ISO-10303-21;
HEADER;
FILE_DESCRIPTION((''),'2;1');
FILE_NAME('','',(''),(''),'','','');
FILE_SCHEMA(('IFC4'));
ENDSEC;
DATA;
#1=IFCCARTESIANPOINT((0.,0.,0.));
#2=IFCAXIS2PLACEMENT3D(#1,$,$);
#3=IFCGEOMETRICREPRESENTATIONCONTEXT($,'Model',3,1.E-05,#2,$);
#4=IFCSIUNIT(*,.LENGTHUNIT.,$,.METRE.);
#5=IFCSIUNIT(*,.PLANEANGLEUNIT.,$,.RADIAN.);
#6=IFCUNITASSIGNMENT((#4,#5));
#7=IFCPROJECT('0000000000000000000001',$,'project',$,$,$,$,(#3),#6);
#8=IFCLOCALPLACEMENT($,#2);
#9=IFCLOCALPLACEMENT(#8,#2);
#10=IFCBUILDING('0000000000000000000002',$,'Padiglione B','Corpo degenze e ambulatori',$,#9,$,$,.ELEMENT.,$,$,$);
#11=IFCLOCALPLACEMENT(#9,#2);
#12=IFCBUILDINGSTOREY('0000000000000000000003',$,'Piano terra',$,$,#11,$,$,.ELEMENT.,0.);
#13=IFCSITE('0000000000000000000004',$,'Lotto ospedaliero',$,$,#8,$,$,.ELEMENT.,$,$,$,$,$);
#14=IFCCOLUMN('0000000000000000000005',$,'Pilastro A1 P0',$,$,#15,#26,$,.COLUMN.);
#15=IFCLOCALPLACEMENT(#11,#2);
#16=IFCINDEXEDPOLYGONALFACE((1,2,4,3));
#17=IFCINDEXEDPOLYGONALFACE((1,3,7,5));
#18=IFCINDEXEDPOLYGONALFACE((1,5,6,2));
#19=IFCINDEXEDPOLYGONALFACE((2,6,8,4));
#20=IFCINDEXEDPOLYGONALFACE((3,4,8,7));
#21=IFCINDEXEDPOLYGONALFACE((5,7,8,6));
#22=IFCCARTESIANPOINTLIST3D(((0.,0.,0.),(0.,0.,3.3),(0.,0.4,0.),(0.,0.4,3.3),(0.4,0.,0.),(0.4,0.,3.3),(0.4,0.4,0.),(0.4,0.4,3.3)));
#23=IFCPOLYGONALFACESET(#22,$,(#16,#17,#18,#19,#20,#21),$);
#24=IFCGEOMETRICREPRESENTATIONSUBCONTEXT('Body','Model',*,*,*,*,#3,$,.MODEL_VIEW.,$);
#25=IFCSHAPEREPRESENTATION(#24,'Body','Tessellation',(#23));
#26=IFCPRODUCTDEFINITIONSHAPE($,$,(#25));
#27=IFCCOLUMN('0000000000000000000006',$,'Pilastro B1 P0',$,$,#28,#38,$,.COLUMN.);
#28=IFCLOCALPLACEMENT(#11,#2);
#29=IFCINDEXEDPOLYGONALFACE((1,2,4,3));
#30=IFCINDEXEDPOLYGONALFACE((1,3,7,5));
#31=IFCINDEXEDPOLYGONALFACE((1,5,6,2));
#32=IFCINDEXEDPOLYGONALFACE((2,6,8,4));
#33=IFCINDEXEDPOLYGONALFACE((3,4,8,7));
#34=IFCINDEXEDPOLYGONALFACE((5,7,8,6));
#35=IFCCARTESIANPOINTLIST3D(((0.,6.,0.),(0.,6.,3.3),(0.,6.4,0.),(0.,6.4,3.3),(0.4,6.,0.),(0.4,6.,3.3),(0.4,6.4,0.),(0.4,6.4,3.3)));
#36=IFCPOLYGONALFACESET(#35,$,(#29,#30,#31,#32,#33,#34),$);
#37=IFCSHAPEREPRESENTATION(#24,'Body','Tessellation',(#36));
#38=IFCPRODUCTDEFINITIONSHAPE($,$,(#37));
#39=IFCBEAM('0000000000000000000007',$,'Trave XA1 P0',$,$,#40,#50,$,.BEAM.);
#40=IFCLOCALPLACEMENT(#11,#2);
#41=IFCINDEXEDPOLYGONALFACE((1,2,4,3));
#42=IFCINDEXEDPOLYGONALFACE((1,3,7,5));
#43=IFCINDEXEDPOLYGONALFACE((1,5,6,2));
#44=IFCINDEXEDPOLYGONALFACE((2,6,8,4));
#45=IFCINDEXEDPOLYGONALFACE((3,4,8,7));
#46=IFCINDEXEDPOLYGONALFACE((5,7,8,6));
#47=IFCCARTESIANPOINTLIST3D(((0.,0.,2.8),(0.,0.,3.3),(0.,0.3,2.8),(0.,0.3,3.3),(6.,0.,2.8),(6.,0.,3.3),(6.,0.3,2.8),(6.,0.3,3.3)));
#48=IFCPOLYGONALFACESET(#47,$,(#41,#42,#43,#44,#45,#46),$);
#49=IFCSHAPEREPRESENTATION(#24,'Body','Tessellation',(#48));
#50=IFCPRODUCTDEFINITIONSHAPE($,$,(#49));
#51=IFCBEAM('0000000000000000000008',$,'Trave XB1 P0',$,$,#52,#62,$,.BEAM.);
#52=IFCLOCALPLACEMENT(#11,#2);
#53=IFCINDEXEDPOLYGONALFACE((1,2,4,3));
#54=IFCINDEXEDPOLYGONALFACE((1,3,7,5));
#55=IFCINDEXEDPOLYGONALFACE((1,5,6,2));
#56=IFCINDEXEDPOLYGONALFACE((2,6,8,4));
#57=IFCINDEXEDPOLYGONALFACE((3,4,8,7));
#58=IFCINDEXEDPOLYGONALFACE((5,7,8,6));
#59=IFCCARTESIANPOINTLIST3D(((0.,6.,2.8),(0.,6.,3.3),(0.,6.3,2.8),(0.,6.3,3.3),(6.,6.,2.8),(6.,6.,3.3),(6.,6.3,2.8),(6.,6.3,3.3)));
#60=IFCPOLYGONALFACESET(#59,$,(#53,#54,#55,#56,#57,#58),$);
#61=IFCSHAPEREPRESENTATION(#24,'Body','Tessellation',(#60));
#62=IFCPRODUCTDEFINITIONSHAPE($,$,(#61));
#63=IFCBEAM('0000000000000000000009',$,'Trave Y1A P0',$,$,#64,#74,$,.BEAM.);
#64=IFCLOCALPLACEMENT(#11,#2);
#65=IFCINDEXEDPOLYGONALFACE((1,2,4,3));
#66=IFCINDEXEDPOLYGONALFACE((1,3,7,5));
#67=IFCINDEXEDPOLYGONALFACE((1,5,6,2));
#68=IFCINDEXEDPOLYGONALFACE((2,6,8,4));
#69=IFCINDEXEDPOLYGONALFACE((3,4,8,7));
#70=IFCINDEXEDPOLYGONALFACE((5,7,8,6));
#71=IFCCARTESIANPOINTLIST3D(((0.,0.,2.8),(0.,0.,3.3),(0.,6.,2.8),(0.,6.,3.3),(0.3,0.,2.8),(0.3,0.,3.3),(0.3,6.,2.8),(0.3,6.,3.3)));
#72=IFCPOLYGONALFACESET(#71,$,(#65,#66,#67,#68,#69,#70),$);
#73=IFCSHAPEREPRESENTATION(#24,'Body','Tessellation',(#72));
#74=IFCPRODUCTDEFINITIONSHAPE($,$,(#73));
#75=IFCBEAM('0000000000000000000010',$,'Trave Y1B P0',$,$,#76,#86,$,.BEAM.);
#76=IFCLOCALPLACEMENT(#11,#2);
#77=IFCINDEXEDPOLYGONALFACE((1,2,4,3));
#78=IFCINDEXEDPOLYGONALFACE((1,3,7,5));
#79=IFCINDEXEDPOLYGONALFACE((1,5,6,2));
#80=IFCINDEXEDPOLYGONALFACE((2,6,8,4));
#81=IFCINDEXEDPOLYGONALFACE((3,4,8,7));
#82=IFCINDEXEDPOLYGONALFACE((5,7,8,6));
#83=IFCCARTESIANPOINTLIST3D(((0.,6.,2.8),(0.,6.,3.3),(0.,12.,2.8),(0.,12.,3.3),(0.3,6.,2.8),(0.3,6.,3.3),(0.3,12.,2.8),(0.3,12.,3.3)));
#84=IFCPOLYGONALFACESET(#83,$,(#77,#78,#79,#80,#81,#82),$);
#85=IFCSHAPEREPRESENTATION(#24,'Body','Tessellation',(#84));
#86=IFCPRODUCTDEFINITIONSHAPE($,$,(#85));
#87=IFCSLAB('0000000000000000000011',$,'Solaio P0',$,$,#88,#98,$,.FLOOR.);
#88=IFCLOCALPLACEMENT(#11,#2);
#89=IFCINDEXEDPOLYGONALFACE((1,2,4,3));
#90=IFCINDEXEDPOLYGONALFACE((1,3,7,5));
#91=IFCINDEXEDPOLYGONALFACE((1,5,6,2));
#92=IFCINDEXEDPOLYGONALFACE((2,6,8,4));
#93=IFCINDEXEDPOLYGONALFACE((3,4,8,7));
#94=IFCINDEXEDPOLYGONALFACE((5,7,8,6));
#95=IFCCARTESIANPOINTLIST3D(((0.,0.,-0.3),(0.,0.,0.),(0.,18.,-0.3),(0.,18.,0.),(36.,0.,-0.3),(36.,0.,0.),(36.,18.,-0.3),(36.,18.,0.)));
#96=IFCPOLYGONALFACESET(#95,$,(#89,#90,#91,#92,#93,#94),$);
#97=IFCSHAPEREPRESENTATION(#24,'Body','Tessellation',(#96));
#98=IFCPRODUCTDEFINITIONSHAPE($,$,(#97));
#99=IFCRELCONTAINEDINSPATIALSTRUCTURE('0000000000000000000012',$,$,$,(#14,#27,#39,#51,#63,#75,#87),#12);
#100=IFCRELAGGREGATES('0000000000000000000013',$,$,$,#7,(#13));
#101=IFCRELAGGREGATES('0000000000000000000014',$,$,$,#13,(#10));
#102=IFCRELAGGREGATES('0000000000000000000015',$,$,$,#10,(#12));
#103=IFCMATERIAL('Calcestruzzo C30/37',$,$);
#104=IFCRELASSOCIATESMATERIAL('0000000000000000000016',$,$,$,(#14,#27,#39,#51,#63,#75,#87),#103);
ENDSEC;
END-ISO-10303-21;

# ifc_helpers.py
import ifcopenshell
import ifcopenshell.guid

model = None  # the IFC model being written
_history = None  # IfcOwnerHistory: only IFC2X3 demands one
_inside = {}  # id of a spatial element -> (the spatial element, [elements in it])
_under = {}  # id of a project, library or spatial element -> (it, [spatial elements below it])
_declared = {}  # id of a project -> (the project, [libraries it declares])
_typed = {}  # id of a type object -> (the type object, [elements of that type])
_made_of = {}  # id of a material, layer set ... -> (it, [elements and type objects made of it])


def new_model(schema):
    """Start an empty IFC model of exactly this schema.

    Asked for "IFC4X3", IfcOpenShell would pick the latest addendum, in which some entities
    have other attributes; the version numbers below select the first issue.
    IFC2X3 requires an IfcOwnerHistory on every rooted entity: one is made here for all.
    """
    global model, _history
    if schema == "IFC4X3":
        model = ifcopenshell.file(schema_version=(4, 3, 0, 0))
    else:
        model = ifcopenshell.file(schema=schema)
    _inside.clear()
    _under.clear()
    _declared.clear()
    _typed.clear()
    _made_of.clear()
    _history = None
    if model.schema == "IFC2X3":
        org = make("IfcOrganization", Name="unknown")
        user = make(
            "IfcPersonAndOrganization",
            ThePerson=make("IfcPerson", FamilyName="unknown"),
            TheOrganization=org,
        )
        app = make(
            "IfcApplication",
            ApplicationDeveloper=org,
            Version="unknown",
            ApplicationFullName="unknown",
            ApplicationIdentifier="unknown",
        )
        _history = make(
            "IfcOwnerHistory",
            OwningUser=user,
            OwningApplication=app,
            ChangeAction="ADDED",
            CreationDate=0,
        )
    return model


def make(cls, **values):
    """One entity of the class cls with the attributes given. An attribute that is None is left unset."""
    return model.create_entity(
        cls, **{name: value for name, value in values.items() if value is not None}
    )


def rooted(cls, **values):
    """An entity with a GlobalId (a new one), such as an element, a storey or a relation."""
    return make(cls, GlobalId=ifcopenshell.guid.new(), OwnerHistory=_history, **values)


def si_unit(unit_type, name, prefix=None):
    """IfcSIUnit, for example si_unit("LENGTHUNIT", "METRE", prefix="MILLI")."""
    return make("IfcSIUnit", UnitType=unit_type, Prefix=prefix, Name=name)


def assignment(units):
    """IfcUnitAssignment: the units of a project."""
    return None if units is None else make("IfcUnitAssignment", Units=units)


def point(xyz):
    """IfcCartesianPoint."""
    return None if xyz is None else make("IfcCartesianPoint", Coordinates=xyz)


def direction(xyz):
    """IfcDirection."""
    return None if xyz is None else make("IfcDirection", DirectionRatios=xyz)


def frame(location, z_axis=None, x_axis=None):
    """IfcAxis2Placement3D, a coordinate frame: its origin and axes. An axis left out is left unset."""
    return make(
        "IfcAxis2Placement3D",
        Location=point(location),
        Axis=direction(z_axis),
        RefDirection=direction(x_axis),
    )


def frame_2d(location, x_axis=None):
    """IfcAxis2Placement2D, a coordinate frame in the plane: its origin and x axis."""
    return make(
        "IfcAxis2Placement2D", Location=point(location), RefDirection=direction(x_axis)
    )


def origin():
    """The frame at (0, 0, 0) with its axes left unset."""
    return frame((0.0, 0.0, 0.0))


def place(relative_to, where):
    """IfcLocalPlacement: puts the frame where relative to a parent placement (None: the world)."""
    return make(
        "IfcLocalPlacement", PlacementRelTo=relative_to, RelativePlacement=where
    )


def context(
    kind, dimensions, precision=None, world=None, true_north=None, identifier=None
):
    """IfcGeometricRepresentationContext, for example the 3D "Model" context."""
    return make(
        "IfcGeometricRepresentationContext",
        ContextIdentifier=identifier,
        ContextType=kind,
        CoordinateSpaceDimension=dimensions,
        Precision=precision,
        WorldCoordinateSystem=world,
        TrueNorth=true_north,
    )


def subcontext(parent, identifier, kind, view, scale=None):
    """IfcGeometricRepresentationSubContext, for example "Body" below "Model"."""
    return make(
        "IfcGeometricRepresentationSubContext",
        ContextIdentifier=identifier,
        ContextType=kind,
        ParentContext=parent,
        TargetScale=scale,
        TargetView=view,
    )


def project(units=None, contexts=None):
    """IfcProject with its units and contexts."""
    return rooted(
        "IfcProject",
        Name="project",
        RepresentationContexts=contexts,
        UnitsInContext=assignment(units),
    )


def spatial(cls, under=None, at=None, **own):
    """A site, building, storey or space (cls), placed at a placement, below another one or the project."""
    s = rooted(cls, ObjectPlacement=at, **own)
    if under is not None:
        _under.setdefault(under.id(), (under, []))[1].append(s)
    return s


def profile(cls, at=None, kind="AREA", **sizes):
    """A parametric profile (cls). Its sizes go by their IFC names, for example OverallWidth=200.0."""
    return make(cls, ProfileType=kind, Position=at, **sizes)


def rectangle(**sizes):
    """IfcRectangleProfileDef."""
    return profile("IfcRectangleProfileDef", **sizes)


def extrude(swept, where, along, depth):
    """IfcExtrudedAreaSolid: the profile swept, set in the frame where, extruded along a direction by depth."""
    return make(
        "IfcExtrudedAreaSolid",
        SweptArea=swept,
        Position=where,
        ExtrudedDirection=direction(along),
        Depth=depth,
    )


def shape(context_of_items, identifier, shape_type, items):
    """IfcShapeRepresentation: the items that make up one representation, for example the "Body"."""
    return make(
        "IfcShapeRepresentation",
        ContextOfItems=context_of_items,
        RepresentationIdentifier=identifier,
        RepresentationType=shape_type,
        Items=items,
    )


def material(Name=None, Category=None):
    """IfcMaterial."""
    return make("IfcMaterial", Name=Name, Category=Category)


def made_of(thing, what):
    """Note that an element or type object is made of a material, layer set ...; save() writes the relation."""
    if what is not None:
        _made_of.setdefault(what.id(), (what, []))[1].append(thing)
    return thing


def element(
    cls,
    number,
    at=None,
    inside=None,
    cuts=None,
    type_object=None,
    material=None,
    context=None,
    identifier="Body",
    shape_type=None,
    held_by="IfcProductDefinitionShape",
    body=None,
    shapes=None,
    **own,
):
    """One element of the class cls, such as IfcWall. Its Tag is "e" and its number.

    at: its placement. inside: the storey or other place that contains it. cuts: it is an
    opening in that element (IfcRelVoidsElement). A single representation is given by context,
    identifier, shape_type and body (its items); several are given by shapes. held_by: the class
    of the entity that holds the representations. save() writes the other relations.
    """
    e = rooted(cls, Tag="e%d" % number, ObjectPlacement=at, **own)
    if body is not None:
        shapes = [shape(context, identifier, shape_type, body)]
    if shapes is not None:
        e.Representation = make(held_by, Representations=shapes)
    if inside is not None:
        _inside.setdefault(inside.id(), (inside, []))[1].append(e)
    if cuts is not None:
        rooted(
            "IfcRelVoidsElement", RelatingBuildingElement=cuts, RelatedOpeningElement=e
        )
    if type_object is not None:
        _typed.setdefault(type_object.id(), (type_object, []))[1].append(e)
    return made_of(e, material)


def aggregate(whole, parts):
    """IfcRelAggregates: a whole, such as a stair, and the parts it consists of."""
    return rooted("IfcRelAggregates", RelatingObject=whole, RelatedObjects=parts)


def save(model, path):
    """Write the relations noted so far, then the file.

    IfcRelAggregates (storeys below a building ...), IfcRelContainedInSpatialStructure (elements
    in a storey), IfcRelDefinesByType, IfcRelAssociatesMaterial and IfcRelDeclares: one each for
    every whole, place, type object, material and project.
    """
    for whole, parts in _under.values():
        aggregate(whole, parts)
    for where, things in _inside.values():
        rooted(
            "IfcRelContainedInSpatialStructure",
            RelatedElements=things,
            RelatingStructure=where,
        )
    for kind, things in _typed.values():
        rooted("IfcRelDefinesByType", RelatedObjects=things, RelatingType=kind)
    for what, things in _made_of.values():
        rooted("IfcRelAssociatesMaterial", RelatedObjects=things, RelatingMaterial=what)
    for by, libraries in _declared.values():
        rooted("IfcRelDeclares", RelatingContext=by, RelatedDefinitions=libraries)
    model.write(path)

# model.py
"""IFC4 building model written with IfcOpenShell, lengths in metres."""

from ifc_helpers import new_model, si_unit, frame, frame_2d, origin, place, context, subcontext, project, spatial, rectangle, extrude, material, element, save


model = new_model("IFC4")

# Units and contexts
model_context = context("Model", 3, precision=1e-05, world=origin())
body_context = subcontext(model_context, "Body", "Model", "MODEL_VIEW")
ifc_project = project(units=[si_unit("LENGTHUNIT", "METRE"), si_unit("PLANEANGLEUNIT", "RADIAN")], contexts=[model_context])

# Site, building, storey
site_placement = place(None, origin())
site = spatial("IfcSite", under=ifc_project, at=site_placement, Name="Lotto ospedaliero", CompositionType="ELEMENT")
building_placement = place(site_placement, origin())
building = spatial("IfcBuilding", under=site, at=building_placement, Name="Padiglione B", Description="Corpo degenze e ambulatori", CompositionType="ELEMENT")
storey_placement = place(building_placement, origin())
storey = spatial("IfcBuildingStorey", under=building, at=storey_placement, Name="Piano terra", CompositionType="ELEMENT", Elevation=0.0)

# Columns
ifc_material_1 = material(Name="Calcestruzzo C30/37")
for number, where, name in (
    (1, (0.0, 0.0, 0.0), "Pilastro A1 P0"),
    (2, (0.0, 6.0, 0.0), "Pilastro B1 P0"),
):
    element("IfcColumn", number, at=place(storey_placement, frame(where)), inside=storey, material=ifc_material_1, Name=name, PredefinedType="COLUMN", context=body_context, shape_type="SweptSolid", body=[
        extrude(rectangle(XDim=0.4, YDim=0.4, at=frame_2d((0.2, 0.2))), origin(), (0.0, 0.0, 1.0), 3.3),
    ])

# Beams
for number, where, name in (
    (3, (0.0, 0.0, 2.8), "Trave XA1 P0"),
    (4, (0.0, 6.0, 2.8), "Trave XB1 P0"),
):
    element("IfcBeam", number, at=place(storey_placement, frame(where)), inside=storey, material=ifc_material_1, Name=name, PredefinedType="BEAM", context=body_context, shape_type="SweptSolid", body=[
        extrude(rectangle(XDim=6.0, YDim=0.3, at=frame_2d((3.0, 0.15))), origin(), (0.0, 0.0, 1.0), 0.5),
    ])
for number, where, name in (
    (5, (0.0, 0.0, 2.8), "Trave Y1A P0"),
    (6, (0.0, 6.0, 2.8), "Trave Y1B P0"),
):
    element("IfcBeam", number, at=place(storey_placement, frame(where)), inside=storey, material=ifc_material_1, Name=name, PredefinedType="BEAM", context=body_context, shape_type="SweptSolid", body=[
        extrude(rectangle(XDim=0.3, YDim=6.0, at=frame_2d((0.15, 3.0))), origin(), (0.0, 0.0, 1.0), 0.5),
    ])

# Slab
slab_placement = place(storey_placement, frame((0.0, 0.0, -0.3)))
element("IfcSlab", 7, at=slab_placement, inside=storey, material=ifc_material_1, Name="Solaio P0", PredefinedType="FLOOR", context=body_context, shape_type="SweptSolid", body=[
    extrude(rectangle(XDim=36.0, YDim=18.0, at=frame_2d((18.0, 9.0))), origin(), (0.0, 0.0, 1.0), 0.3),
])

save(model, "model.ifc")
